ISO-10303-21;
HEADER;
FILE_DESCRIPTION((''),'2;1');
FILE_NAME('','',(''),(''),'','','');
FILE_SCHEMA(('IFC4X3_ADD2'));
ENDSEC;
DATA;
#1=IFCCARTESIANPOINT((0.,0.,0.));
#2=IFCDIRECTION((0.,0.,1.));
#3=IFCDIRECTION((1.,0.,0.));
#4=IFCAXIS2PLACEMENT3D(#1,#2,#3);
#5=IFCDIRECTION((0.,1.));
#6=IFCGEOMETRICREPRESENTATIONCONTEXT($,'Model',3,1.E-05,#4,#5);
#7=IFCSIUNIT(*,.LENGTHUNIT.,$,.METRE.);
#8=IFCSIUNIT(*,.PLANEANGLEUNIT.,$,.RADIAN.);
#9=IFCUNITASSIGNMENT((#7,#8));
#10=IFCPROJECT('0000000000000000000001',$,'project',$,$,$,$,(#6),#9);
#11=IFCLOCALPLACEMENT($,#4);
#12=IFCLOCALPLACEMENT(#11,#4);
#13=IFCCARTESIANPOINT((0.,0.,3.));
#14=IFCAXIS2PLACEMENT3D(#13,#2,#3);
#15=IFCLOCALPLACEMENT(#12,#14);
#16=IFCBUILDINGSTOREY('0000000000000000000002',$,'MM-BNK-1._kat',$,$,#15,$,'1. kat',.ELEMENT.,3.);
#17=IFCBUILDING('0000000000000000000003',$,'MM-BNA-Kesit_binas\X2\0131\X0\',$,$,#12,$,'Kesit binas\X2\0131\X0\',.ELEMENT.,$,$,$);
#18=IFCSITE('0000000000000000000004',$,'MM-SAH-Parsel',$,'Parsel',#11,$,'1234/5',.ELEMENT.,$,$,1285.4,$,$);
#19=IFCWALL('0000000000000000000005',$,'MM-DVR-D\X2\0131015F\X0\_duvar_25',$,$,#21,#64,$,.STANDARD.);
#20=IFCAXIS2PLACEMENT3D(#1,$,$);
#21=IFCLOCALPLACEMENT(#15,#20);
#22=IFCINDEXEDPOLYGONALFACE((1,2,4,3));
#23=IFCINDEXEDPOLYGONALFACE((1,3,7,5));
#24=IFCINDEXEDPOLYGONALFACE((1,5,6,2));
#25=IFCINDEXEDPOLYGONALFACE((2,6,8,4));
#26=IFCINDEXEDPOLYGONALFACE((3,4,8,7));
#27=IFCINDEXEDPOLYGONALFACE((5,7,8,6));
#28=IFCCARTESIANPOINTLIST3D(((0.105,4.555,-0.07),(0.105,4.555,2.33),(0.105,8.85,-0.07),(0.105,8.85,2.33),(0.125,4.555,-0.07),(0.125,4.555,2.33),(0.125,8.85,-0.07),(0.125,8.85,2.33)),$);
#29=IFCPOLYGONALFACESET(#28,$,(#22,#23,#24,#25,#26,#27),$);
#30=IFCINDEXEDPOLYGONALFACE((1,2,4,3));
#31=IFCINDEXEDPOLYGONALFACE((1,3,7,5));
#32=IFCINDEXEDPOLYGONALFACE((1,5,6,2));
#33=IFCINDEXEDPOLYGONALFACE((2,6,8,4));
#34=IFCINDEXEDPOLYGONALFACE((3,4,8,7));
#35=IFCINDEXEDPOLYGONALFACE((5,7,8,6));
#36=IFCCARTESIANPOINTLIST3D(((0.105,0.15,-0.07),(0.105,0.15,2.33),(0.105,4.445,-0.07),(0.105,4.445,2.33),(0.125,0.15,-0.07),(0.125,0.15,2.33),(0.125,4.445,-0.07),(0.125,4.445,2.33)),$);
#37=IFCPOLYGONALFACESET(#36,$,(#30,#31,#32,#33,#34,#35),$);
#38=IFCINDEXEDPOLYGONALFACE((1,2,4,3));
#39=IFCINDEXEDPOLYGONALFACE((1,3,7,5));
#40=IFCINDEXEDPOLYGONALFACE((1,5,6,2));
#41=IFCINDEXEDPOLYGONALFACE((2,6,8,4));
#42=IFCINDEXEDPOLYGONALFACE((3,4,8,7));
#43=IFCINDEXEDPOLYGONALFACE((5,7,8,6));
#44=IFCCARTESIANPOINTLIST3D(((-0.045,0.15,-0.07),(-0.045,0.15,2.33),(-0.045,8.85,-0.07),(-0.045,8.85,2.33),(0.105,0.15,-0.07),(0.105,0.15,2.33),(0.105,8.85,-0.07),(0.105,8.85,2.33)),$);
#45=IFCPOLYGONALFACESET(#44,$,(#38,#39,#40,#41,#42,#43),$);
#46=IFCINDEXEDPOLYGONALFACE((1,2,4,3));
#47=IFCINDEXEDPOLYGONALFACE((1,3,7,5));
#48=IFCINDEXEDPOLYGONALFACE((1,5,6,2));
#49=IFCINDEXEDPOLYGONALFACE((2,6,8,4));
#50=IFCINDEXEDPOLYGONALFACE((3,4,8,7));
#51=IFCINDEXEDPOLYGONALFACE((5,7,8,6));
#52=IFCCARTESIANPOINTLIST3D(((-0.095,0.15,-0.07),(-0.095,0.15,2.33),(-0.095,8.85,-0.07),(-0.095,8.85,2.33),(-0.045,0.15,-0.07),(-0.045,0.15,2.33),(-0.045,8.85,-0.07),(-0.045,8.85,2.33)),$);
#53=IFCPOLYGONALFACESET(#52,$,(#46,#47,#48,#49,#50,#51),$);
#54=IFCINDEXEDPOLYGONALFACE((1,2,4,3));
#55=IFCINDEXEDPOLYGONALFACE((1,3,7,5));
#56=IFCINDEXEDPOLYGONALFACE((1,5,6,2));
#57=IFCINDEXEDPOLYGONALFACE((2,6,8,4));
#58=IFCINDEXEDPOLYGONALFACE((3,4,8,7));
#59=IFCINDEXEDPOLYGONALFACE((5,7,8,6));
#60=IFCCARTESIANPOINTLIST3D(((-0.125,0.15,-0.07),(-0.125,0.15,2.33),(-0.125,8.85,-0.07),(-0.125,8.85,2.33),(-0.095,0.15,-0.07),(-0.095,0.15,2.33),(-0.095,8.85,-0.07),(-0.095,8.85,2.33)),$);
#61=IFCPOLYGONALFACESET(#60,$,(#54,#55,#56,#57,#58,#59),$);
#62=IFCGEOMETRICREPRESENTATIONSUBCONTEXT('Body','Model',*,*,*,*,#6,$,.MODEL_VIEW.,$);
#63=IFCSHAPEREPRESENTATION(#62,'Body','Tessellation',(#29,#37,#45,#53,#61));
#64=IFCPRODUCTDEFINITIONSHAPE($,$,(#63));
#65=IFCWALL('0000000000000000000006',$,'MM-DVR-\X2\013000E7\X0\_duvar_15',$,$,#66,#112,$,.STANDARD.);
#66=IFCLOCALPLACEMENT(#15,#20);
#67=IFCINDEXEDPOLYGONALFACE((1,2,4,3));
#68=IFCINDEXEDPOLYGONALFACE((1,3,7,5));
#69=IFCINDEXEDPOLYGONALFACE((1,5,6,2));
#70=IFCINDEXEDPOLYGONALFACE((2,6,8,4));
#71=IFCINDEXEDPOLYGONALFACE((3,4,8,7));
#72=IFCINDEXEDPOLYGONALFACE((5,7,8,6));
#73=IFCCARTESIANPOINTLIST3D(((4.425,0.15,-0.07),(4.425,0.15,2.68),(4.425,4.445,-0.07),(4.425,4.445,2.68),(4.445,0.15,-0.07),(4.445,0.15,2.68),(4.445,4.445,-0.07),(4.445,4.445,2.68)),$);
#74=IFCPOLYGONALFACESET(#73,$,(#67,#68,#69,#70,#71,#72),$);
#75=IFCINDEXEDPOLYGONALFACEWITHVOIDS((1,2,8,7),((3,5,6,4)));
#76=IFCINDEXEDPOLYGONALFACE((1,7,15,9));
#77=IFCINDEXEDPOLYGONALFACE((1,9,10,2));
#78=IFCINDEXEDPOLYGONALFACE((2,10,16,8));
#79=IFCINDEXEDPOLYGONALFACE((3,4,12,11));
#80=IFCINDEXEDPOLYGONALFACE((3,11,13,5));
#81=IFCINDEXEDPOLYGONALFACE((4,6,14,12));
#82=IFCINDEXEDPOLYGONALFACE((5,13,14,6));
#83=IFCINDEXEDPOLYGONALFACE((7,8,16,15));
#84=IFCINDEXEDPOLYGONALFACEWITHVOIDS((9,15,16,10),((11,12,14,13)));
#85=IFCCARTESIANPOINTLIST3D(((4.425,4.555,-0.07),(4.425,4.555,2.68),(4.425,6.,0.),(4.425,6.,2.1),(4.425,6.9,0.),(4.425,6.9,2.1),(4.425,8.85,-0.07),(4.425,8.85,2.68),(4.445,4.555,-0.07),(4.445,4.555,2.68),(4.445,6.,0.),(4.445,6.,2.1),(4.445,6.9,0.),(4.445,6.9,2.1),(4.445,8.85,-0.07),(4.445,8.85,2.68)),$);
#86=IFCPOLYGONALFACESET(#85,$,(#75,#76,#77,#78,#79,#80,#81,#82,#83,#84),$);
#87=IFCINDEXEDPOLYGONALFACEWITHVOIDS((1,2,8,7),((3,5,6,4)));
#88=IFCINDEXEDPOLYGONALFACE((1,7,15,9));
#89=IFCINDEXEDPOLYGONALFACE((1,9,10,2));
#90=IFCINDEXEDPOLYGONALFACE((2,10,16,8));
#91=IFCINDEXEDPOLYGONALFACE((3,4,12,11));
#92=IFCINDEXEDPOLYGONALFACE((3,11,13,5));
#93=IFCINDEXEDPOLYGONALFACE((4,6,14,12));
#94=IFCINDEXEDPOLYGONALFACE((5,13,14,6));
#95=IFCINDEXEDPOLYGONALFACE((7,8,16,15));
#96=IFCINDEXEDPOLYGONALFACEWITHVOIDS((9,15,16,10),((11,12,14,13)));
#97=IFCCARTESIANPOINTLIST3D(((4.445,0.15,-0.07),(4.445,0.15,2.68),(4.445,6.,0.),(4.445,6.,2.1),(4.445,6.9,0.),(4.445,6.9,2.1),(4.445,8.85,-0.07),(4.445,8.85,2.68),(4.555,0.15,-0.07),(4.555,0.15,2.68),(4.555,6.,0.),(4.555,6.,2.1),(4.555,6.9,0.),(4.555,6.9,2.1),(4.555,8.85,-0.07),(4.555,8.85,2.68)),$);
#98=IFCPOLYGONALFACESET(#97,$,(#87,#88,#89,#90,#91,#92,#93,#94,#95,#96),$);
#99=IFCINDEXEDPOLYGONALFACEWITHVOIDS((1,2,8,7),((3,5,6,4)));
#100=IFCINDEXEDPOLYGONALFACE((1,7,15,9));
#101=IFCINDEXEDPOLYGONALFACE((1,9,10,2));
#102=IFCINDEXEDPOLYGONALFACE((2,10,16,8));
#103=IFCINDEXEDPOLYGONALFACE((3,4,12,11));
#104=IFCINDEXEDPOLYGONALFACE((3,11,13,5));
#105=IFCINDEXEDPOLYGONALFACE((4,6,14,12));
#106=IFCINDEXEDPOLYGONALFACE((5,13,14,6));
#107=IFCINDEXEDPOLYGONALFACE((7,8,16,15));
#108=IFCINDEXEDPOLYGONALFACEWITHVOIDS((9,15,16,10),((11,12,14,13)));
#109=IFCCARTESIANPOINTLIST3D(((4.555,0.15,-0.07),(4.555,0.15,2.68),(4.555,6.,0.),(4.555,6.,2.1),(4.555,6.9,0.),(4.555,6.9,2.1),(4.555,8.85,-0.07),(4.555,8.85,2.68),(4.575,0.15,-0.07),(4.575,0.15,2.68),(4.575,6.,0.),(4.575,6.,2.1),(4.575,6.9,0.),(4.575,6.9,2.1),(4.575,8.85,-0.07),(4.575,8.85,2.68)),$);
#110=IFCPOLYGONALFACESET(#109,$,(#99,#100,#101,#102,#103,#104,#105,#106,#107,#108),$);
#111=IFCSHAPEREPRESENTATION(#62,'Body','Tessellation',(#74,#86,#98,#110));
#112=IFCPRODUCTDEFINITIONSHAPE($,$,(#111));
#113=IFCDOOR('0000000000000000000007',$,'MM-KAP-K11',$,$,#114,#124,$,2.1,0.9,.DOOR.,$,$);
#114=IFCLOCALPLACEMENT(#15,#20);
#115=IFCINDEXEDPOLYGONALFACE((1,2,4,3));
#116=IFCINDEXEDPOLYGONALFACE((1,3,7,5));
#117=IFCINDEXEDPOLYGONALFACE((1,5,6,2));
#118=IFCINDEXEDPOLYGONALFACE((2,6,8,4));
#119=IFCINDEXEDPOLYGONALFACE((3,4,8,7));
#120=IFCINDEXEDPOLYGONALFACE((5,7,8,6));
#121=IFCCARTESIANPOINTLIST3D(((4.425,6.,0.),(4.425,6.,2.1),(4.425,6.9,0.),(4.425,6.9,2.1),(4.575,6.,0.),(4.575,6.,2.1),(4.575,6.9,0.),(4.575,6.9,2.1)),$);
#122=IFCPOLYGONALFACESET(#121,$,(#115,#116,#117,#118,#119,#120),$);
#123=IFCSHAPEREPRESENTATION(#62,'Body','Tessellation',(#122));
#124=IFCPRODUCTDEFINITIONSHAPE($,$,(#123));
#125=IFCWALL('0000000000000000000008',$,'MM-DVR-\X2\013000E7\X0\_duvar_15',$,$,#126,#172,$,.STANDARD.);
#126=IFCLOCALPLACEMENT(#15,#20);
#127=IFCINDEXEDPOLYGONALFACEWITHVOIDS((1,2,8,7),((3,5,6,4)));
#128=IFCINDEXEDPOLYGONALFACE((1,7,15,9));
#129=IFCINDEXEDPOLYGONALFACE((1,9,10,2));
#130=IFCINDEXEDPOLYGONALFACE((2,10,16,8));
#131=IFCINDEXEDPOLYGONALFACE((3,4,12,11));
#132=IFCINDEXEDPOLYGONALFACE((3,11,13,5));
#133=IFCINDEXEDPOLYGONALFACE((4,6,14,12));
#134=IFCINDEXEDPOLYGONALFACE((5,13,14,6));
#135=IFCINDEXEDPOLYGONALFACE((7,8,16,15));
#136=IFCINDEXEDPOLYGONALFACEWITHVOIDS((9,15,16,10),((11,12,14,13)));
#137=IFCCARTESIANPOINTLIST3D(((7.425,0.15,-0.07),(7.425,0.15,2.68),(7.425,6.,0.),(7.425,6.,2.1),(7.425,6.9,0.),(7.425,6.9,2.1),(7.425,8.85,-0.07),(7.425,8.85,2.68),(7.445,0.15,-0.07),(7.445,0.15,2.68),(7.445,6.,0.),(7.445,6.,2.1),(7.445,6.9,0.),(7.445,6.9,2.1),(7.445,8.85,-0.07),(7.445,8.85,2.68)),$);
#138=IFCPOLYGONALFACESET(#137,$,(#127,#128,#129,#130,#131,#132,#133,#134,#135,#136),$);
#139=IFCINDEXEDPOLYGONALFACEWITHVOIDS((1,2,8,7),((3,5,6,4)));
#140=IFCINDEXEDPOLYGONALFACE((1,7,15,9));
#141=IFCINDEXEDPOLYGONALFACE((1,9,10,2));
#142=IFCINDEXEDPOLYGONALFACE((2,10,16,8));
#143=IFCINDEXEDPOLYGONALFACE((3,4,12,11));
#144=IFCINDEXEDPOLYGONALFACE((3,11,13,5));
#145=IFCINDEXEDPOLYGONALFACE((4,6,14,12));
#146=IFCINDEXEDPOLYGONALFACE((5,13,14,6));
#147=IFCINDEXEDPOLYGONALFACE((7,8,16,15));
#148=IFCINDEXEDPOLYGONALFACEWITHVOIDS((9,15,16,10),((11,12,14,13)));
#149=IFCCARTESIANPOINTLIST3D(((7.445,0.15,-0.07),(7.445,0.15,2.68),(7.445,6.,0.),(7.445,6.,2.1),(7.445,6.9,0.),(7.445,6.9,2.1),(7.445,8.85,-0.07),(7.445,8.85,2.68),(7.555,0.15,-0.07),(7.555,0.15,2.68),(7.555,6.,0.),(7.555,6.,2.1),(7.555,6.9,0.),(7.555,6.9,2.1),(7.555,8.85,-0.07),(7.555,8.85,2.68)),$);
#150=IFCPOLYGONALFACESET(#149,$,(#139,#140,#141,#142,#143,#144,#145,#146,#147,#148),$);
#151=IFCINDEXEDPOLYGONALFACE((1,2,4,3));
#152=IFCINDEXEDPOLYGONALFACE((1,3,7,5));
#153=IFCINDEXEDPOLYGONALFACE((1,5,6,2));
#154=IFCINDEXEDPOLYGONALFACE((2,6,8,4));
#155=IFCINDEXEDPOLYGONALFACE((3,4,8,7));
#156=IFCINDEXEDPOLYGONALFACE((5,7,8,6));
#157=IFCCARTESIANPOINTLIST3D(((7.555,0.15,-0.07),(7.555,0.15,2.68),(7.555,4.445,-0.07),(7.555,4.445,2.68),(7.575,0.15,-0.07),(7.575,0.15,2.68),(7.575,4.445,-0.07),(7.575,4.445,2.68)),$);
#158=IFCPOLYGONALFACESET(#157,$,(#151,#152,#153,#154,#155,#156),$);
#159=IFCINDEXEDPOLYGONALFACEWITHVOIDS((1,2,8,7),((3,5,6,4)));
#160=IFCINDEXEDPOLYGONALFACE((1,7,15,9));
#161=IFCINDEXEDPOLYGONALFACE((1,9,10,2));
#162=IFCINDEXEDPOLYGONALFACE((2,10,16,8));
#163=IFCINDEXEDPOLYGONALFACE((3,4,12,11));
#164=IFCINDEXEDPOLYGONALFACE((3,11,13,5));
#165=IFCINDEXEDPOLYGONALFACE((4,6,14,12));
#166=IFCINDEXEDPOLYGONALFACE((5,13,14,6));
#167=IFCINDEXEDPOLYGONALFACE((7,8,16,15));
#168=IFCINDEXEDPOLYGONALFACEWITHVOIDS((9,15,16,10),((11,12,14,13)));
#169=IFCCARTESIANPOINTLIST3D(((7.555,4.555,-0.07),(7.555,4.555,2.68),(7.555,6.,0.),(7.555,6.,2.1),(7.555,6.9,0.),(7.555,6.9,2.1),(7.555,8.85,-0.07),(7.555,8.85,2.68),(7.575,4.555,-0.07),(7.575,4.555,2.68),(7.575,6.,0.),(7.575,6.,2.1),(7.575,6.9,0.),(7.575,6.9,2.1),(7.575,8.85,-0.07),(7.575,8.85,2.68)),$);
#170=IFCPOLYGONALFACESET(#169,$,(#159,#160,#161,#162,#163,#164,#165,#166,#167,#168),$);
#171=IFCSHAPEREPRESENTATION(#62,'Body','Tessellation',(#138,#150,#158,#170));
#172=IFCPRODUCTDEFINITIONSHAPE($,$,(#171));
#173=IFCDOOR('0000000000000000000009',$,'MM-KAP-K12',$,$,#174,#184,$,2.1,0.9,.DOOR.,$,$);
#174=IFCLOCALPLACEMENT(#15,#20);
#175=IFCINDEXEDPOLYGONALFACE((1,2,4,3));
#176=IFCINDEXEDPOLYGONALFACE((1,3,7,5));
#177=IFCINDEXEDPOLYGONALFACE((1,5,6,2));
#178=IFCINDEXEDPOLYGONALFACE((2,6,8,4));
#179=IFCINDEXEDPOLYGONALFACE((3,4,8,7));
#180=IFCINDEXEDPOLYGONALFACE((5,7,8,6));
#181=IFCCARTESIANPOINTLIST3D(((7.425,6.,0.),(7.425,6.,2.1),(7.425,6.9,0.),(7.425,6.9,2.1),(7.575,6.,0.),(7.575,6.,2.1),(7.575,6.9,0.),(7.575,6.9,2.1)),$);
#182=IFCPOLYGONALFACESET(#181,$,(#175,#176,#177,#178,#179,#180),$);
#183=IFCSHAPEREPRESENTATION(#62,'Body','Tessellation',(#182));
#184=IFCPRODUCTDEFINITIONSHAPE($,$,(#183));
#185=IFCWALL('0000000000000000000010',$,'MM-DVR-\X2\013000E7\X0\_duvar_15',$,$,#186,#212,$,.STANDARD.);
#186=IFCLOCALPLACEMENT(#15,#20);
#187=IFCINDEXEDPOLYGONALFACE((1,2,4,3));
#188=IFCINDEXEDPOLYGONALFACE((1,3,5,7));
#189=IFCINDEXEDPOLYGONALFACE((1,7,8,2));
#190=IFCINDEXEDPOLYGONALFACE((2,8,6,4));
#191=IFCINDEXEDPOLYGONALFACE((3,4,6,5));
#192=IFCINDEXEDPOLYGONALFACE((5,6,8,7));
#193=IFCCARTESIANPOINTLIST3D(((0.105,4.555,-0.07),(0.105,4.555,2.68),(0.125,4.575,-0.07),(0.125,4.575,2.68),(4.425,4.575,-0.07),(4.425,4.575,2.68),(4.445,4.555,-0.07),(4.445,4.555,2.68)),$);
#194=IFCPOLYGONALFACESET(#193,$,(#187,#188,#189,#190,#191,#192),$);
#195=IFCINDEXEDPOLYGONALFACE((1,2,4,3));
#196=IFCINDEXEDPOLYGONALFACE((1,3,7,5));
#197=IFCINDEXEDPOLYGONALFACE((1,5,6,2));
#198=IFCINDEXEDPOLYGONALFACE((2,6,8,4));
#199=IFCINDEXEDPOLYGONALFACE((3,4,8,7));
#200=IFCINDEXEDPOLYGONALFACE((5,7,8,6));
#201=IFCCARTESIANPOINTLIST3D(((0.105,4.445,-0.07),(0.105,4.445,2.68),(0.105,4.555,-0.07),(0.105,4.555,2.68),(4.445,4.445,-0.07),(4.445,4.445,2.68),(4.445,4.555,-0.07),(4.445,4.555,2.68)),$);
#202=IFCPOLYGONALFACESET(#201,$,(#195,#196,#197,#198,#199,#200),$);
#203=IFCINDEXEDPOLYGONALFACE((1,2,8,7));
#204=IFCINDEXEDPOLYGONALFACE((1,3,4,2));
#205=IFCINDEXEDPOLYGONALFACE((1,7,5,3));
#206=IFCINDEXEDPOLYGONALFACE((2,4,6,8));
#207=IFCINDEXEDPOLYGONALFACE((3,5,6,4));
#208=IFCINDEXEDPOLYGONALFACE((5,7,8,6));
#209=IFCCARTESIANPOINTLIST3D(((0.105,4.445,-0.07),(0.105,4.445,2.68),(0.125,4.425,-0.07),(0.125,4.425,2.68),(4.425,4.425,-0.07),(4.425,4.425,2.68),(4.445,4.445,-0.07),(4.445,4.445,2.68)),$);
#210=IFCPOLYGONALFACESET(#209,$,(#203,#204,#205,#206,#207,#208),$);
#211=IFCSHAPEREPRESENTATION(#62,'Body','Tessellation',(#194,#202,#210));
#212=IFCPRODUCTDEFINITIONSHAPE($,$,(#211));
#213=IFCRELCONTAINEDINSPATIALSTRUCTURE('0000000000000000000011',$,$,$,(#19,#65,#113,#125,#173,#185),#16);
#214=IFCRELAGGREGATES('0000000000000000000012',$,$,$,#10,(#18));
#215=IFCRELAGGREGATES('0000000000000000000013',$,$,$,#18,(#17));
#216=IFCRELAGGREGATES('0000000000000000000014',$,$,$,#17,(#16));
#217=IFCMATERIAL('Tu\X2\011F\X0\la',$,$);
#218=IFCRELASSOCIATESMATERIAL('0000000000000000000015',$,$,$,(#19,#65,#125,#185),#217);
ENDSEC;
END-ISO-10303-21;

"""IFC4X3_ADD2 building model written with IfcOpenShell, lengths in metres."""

from ifc_helpers import new_model, si_unit, direction, frame, origin, origin_with_axes, place, context, subcontext, project, spatial, polyline, outline, extrude, material, element, fill, save


model = new_model("IFC4X3_ADD2")

# Units and contexts
model_context = context("Model", 3, precision=1e-05, world=origin_with_axes(), true_north=direction((0.0, 1.0)))
body_context = subcontext(model_context, "Body", "Model", "MODEL_VIEW")
ifc_project = project(units=[si_unit("LENGTHUNIT", "METRE"), si_unit("PLANEANGLEUNIT", "RADIAN")], contexts=[model_context])

# Site, building, storey
site_placement = place(None, origin_with_axes())
site = spatial("IfcSite", under=ifc_project, at=site_placement, Name="MM-SAH-Parsel", ObjectType="Parsel", LongName="1234/5", CompositionType="ELEMENT", RefElevation=1285.4)
building_placement = place(site_placement, origin_with_axes())
building = spatial("IfcBuilding", under=site, at=building_placement, Name="MM-BNA-Kesit_binası", LongName="Kesit binası", CompositionType="ELEMENT")
storey_placement = place(building_placement, frame((0.0, 0.0, 3.0), z_axis=(0.0, 0.0, 1.0), x_axis=(1.0, 0.0, 0.0)))
storey = spatial("IfcBuildingStorey", under=building, at=storey_placement, Name="MM-BNK-1._kat", LongName="1. kat", CompositionType="ELEMENT", Elevation=3.0)

# Shared definitions
ifc_material_1 = material(Name="Tuğla")

# Wall
wall_1_placement = place(storey_placement, origin_with_axes())
element("IfcWall", 1, at=wall_1_placement, inside=storey, material=ifc_material_1, Name="MM-DVR-Dış_duvar_25", PredefinedType="STANDARD", context=body_context, shape_type="SweptSolid", body=[
    extrude(outline(polyline([(0.105, 8.85), (0.105, 4.555), (0.125, 4.555), (0.125, 8.85), (0.105, 8.85)])), frame((0.0, 0.0, -0.07)), (0.0, 0.0, 1.0), 2.4),
    extrude(outline(polyline([(0.105, 4.445), (0.105, 0.15), (0.125, 0.15), (0.125, 4.445), (0.105, 4.445)])), frame((0.0, 0.0, -0.07)), (0.0, 0.0, 1.0), 2.4),
    extrude(outline(polyline([(-0.045, 8.85), (-0.045, 0.15), (0.105, 0.15), (0.105, 8.85), (-0.045, 8.85)])), frame((0.0, 0.0, -0.07)), (0.0, 0.0, 1.0), 2.4),
    extrude(outline(polyline([(-0.095, 8.85), (-0.095, 0.15), (-0.045, 0.15), (-0.045, 8.85), (-0.095, 8.85)])), frame((0.0, 0.0, -0.07)), (0.0, 0.0, 1.0), 2.4),
    extrude(outline(polyline([(-0.125, 8.85), (-0.125, 0.15), (-0.095, 0.15), (-0.095, 8.85), (-0.125, 8.85)])), frame((0.0, 0.0, -0.07)), (0.0, 0.0, 1.0), 2.4),
])

# Walls, openings, doors
wall_2_placement = place(storey_placement, origin_with_axes())
wall_2 = element("IfcWall", 2, at=wall_2_placement, inside=storey, material=ifc_material_1, Name="MM-DVR-İç_duvar_15", PredefinedType="STANDARD", context=body_context, shape_type="SweptSolid", body=[
    extrude(outline(polyline([(4.445, 0.15), (4.445, 4.445), (4.425, 4.445), (4.425, 0.15), (4.445, 0.15)])), frame((0.0, 0.0, -0.07)), (0.0, 0.0, 1.0), 2.75),
    extrude(outline(polyline([(4.445, 4.555), (4.445, 8.85), (4.425, 8.85), (4.425, 4.555), (4.445, 4.555)])), frame((0.0, 0.0, -0.07)), (0.0, 0.0, 1.0), 2.75),
    extrude(outline(polyline([(4.555, 0.15), (4.555, 8.85), (4.445, 8.85), (4.445, 0.15), (4.555, 0.15)])), frame((0.0, 0.0, -0.07)), (0.0, 0.0, 1.0), 2.75),
    extrude(outline(polyline([(4.575, 0.15), (4.575, 8.85), (4.555, 8.85), (4.555, 0.15), (4.575, 0.15)])), frame((0.0, 0.0, -0.07)), (0.0, 0.0, 1.0), 2.75),
])
opening_1_placement = place(storey_placement, origin_with_axes())
opening_1 = element("IfcOpeningElement", 3, at=opening_1_placement, cuts=wall_2, PredefinedType="OPENING", context=body_context, shape_type="SweptSolid", body=[
    extrude(outline(polyline([(4.425, 6.0), (4.425, 6.9), (4.575, 6.9), (4.575, 6.0), (4.425, 6.0)])), origin(), (0.0, 0.0, 1.0), 2.1),
])
door_1_placement = place(storey_placement, origin_with_axes())
door_1 = element("IfcDoor", 4, at=door_1_placement, inside=storey, Name="MM-KAP-K11", OverallHeight=2.1, OverallWidth=0.9, PredefinedType="DOOR", context=body_context, shape_type="SweptSolid", body=[
    extrude(outline(polyline([(4.425, 6.0), (4.425, 6.9), (4.575, 6.9), (4.575, 6.0), (4.425, 6.0)])), origin(), (0.0, 0.0, 1.0), 2.1),
])
fill(opening_1, door_1)
wall_3_placement = place(storey_placement, origin_with_axes())
wall_3 = element("IfcWall", 5, at=wall_3_placement, inside=storey, material=ifc_material_1, Name="MM-DVR-İç_duvar_15", PredefinedType="STANDARD", context=body_context, shape_type="SweptSolid", body=[
    extrude(outline(polyline([(7.445, 0.15), (7.445, 8.85), (7.425, 8.85), (7.425, 0.15), (7.445, 0.15)])), frame((0.0, 0.0, -0.07)), (0.0, 0.0, 1.0), 2.75),
    extrude(outline(polyline([(7.555, 0.15), (7.555, 8.85), (7.445, 8.85), (7.445, 0.15), (7.555, 0.15)])), frame((0.0, 0.0, -0.07)), (0.0, 0.0, 1.0), 2.75),
    extrude(outline(polyline([(7.575, 0.15), (7.575, 4.445), (7.555, 4.445), (7.555, 0.15), (7.575, 0.15)])), frame((0.0, 0.0, -0.07)), (0.0, 0.0, 1.0), 2.75),
    extrude(outline(polyline([(7.575, 4.555), (7.575, 8.85), (7.555, 8.85), (7.555, 4.555), (7.575, 4.555)])), frame((0.0, 0.0, -0.07)), (0.0, 0.0, 1.0), 2.75),
])
opening_2_placement = place(storey_placement, origin_with_axes())
opening_2 = element("IfcOpeningElement", 6, at=opening_2_placement, cuts=wall_3, PredefinedType="OPENING", context=body_context, shape_type="SweptSolid", body=[
    extrude(outline(polyline([(7.425, 6.0), (7.425, 6.9), (7.575, 6.9), (7.575, 6.0), (7.425, 6.0)])), origin(), (0.0, 0.0, 1.0), 2.1),
])
door_2_placement = place(storey_placement, origin_with_axes())
door_2 = element("IfcDoor", 7, at=door_2_placement, inside=storey, Name="MM-KAP-K12", OverallHeight=2.1, OverallWidth=0.9, PredefinedType="DOOR", context=body_context, shape_type="SweptSolid", body=[
    extrude(outline(polyline([(7.425, 6.0), (7.425, 6.9), (7.575, 6.9), (7.575, 6.0), (7.425, 6.0)])), origin(), (0.0, 0.0, 1.0), 2.1),
])
fill(opening_2, door_2)

# Wall
wall_4_placement = place(storey_placement, origin_with_axes())
element("IfcWall", 8, at=wall_4_placement, inside=storey, material=ifc_material_1, Name="MM-DVR-İç_duvar_15", PredefinedType="STANDARD", context=body_context, shape_type="SweptSolid", body=[
    extrude(outline(polyline([(0.125, 4.575), (4.425, 4.575), (4.445, 4.555), (0.105, 4.555), (0.125, 4.575)])), frame((0.0, 0.0, -0.07)), (0.0, 0.0, 1.0), 2.75),
    extrude(outline(polyline([(0.105, 4.555), (4.445, 4.555), (4.445, 4.445), (0.105, 4.445), (0.105, 4.555)])), frame((0.0, 0.0, -0.07)), (0.0, 0.0, 1.0), 2.75),
    extrude(outline(polyline([(0.105, 4.445), (4.445, 4.445), (4.425, 4.425), (0.125, 4.425), (0.105, 4.445)])), frame((0.0, 0.0, -0.07)), (0.0, 0.0, 1.0), 2.75),
])

save(model, "model.ifc")
